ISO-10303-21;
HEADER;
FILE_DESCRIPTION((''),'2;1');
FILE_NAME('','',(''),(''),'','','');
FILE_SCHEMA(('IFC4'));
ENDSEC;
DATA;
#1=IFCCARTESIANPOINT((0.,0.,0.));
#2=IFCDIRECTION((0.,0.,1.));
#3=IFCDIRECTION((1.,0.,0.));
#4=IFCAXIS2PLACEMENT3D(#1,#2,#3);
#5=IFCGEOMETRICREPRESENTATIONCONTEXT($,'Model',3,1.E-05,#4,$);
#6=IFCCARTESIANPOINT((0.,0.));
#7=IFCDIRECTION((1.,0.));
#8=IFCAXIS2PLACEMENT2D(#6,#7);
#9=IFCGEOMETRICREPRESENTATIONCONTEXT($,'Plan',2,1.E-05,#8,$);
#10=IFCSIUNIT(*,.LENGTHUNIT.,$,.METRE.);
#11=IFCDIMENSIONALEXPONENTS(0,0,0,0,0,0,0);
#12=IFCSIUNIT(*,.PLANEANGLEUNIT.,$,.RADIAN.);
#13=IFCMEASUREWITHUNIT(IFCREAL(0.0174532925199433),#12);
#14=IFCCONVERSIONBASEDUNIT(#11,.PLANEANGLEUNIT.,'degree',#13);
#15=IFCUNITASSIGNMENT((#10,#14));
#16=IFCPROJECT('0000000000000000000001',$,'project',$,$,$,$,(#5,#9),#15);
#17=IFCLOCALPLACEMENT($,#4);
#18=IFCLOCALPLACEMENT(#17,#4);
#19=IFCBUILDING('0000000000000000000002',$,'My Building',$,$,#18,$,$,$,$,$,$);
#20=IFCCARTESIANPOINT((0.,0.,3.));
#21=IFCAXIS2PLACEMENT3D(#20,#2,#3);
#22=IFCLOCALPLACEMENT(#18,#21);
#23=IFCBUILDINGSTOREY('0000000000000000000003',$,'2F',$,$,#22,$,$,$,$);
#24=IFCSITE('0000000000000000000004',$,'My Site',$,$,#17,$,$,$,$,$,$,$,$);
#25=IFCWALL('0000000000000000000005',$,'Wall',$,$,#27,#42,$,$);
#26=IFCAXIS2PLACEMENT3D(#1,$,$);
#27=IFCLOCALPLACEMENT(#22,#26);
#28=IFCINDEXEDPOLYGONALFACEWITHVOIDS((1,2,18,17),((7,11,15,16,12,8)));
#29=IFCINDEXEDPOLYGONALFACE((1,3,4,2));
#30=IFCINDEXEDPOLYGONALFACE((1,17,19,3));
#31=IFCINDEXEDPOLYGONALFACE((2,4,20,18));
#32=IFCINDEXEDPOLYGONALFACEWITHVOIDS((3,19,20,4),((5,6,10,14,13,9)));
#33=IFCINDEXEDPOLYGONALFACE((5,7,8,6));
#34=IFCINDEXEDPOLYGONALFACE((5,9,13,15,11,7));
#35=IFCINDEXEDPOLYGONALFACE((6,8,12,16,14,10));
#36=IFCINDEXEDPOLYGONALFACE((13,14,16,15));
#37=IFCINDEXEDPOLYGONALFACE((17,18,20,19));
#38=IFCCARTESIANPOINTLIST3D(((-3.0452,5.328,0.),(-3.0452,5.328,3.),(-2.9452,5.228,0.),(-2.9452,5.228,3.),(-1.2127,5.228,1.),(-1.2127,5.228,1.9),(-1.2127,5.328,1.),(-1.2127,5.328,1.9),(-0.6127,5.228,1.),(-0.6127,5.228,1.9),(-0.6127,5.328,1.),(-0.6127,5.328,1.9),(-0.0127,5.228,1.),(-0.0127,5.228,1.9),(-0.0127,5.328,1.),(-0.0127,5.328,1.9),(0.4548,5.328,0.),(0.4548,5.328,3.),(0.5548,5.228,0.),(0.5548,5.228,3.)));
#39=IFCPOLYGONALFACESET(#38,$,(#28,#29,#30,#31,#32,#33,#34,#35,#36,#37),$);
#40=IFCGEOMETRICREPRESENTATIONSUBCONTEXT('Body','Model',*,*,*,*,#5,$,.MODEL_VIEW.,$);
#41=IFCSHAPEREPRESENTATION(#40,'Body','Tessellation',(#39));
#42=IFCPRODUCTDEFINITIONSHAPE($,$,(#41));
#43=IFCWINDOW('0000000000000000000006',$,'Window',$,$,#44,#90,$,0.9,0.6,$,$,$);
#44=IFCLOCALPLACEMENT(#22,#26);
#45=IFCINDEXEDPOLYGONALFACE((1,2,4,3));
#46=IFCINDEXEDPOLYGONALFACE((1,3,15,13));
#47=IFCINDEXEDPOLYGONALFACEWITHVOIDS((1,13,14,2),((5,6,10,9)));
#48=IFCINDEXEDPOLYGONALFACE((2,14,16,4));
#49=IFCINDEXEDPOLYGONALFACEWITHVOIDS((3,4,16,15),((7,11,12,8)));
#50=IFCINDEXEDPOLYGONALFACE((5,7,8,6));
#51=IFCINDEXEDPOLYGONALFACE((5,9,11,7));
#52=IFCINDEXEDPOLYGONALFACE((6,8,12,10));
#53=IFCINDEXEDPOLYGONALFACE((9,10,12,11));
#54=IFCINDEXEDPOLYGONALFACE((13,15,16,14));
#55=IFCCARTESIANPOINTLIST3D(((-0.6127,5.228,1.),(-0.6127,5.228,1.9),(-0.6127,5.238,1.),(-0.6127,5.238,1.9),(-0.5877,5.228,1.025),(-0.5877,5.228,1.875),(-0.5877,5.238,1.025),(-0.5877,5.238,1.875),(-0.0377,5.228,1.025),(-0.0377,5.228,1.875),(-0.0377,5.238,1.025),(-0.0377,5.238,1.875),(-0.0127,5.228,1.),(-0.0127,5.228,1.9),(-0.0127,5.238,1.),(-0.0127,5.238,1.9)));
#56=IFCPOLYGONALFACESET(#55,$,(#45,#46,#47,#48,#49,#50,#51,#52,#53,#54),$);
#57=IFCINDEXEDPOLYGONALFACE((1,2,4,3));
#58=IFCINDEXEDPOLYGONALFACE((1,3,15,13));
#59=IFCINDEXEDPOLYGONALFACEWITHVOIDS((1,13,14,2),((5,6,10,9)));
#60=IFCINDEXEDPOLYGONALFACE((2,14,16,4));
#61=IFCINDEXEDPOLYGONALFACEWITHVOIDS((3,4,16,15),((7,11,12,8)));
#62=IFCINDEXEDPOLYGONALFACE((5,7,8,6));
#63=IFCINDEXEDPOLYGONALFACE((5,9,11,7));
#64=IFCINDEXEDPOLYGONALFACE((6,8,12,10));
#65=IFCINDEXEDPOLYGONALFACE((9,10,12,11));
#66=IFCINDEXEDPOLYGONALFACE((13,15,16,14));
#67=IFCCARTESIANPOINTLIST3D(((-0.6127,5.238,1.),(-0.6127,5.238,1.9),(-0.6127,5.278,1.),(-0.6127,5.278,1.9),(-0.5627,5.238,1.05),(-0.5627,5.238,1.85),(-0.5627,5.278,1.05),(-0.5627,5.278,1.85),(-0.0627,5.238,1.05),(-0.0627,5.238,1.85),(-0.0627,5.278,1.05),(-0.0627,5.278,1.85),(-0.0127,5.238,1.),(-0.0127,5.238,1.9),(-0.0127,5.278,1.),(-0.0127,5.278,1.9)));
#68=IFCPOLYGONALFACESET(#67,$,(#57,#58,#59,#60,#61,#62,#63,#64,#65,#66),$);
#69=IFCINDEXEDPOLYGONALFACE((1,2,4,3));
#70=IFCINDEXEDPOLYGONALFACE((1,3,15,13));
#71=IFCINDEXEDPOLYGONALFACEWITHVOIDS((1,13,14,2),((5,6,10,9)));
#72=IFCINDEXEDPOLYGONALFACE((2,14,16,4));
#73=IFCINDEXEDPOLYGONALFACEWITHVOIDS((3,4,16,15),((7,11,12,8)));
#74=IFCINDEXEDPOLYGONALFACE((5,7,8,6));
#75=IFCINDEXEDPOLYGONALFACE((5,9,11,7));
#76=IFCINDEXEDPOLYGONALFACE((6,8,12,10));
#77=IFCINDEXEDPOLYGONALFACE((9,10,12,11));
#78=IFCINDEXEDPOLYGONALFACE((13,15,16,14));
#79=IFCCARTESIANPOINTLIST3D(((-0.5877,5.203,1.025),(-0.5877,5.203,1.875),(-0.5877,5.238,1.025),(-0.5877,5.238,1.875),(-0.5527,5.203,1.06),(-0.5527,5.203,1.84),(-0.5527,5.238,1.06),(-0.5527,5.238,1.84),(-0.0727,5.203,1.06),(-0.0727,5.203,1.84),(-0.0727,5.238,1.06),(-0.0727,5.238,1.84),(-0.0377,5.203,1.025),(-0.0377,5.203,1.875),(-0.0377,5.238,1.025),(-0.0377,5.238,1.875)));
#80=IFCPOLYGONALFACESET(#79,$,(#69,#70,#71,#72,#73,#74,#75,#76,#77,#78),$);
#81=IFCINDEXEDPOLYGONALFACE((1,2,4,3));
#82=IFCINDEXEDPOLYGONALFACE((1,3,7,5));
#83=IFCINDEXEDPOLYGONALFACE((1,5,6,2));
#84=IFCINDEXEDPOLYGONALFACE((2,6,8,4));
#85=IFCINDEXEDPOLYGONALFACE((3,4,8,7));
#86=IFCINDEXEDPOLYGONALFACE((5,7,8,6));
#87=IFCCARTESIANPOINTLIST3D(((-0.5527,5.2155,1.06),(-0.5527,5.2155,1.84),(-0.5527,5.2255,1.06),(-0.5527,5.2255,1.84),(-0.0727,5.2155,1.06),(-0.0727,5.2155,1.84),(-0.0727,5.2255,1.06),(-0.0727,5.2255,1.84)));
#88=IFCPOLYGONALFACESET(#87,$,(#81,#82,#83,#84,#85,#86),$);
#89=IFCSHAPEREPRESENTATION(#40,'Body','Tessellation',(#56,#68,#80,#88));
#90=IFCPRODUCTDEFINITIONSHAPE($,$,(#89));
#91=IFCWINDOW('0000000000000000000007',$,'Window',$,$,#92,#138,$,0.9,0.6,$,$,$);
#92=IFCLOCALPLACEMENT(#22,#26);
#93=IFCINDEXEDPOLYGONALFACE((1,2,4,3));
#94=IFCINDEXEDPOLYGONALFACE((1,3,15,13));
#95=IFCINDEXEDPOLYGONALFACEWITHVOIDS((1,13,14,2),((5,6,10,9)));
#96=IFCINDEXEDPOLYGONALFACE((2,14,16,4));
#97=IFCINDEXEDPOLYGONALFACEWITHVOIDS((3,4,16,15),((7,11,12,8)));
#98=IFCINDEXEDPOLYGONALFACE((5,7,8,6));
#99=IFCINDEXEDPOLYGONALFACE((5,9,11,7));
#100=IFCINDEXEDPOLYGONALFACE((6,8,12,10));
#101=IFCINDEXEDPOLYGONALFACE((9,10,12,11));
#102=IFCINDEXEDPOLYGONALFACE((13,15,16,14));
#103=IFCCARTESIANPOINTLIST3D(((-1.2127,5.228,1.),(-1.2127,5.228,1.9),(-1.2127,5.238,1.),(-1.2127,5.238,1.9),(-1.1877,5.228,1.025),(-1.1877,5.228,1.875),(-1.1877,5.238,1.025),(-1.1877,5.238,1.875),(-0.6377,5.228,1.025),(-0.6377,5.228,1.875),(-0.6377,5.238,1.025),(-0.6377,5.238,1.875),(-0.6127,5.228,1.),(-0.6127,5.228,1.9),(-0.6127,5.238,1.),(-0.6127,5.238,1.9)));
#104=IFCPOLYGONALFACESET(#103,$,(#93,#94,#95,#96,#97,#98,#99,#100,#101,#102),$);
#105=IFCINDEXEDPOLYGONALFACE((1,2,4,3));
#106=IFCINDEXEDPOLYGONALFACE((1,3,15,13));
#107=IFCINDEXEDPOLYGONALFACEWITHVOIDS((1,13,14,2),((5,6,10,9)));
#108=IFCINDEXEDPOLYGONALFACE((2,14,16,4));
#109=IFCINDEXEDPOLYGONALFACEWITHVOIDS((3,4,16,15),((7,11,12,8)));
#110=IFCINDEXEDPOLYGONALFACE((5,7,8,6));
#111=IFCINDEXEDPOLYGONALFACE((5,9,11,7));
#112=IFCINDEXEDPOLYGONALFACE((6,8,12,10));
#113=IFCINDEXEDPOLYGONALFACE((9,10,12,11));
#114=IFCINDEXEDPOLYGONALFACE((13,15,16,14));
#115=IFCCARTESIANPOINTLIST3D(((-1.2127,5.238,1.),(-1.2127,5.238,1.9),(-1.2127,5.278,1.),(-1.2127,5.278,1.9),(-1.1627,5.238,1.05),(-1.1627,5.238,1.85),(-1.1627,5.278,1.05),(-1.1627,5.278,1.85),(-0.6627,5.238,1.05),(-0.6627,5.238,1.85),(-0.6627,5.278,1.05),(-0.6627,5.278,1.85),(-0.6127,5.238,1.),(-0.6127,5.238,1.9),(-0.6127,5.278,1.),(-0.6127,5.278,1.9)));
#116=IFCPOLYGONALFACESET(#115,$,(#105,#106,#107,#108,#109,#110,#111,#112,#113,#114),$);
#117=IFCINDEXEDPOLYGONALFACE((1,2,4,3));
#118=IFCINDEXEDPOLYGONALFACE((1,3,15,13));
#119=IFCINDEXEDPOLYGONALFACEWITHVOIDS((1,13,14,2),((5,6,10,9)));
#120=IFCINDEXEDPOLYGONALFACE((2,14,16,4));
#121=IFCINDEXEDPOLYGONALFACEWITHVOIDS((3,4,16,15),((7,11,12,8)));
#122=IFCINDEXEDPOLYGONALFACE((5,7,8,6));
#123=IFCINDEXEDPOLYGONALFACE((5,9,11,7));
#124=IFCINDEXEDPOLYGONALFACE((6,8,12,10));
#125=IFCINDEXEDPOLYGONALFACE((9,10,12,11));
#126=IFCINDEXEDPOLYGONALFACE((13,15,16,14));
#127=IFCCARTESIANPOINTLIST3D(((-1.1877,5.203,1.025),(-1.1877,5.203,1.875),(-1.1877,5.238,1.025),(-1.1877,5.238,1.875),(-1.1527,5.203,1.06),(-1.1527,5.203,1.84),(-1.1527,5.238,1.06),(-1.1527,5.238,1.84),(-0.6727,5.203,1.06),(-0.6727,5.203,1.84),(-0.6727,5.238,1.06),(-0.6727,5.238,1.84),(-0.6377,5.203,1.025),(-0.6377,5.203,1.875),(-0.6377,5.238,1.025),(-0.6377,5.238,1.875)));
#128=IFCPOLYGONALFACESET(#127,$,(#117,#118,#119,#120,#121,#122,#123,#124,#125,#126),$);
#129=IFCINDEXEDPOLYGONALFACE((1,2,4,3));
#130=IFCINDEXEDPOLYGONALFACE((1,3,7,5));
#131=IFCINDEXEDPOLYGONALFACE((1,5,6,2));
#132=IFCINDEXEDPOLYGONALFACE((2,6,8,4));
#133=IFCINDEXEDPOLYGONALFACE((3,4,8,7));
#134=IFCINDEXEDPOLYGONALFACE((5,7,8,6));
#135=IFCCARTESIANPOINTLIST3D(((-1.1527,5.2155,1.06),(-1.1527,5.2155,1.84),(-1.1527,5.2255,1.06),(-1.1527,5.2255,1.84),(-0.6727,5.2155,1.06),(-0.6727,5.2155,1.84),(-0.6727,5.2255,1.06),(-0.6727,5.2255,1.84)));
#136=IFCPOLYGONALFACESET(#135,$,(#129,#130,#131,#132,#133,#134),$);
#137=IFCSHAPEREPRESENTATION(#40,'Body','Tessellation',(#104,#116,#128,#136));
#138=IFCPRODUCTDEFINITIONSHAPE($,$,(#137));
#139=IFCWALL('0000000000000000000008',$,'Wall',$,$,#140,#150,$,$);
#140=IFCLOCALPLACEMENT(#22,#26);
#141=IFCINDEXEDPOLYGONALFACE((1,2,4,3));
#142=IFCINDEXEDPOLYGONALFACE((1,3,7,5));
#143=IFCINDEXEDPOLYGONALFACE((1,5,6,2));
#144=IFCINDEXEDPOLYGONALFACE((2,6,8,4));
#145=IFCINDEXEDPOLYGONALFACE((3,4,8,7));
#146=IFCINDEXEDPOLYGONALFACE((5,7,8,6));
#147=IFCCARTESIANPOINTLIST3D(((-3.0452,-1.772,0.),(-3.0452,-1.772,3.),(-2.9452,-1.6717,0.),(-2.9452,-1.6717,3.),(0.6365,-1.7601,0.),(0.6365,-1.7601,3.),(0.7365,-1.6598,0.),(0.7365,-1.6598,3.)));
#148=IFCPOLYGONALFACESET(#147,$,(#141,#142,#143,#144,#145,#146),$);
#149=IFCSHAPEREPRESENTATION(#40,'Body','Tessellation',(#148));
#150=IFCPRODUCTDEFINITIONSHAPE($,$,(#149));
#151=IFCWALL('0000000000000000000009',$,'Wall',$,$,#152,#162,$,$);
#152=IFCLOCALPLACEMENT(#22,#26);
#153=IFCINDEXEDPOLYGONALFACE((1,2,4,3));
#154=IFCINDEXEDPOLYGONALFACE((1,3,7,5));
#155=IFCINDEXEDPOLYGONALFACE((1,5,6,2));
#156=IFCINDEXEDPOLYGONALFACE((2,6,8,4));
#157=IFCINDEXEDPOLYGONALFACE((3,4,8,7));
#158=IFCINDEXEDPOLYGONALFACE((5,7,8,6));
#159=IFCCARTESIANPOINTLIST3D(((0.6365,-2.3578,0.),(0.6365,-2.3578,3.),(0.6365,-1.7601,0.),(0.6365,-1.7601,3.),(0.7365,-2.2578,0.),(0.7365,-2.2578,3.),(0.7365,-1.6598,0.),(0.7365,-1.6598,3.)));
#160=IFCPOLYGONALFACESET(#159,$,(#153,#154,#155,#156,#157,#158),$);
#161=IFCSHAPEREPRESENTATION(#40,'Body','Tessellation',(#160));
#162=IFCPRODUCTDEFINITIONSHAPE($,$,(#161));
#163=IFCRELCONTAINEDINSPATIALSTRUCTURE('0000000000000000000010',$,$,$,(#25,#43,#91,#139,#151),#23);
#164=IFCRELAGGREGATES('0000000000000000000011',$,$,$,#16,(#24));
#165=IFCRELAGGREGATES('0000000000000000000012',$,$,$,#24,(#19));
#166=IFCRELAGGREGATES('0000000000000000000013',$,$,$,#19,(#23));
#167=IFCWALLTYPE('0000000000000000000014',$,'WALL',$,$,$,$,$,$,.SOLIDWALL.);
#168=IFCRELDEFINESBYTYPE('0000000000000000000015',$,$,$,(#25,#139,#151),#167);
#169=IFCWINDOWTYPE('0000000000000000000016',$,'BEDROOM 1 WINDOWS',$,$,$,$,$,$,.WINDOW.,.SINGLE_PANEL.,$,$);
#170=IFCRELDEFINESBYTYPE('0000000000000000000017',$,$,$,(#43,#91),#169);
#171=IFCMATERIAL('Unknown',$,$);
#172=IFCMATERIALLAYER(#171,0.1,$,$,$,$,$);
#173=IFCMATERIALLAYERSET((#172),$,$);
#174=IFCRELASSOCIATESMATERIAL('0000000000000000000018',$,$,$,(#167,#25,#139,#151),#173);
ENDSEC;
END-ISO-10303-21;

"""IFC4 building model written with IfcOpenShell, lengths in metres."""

from ifc_helpers import new_model, entity, si_unit, converted_unit, frame, origin_with_axes, origin_2d_with_axis, place, context, subcontext, project, spatial, line, indexed_curve, outline, extrude, shape, source, transform, mapped, material, layer, layer_set, layer_usage, type_object, type_shapes, element, fill, save


model = new_model("IFC4")

# Units and contexts
model_context = context("Model", 3, precision=1e-05, world=origin_with_axes())
plan_context = context("Plan", 2, precision=1e-05, world=origin_2d_with_axis())
body_context_1 = subcontext(model_context, "Body", "Model", "MODEL_VIEW")
body_context_2 = subcontext(plan_context, "Body", "Plan", "PLAN_VIEW")
ifc_project = project(units=[si_unit("LENGTHUNIT", "METRE"), converted_unit("PLANEANGLEUNIT", "degree", entity("IfcReal", 0.0174532925199433), si_unit("PLANEANGLEUNIT", "RADIAN"), dimensions=[0, 0, 0, 0, 0, 0, 0])], contexts=[model_context, plan_context])

# Site, building, storey
site_placement = place(None, origin_with_axes())
site = spatial("IfcSite", under=ifc_project, at=site_placement, Name="My Site")
building_placement = place(site_placement, origin_with_axes())
building = spatial("IfcBuilding", under=site, at=building_placement, Name="My Building")
storey_placement = place(building_placement, frame((0.0, 0.0, 3.0), z_axis=(0.0, 0.0, 1.0), x_axis=(1.0, 0.0, 0.0)))
storey = spatial("IfcBuildingStorey", under=building, at=storey_placement, Name="2F")

# Shared definitions
ifc_material = material(Name="Unknown")

# Shared definitions
ifc_layer_1 = layer(ifc_material, 0.1)
ifc_layer_set_1 = layer_set([ifc_layer_1])
wall_type_1 = type_object("IfcWallType", Name="WALL", PredefinedType="SOLIDWALL", material=ifc_layer_set_1)

# Wall, openings, windows
ifc_layer_usage_1 = layer_usage(ifc_layer_set_1, "AXIS2", "POSITIVE", 0.0)
wall_1_placement = place(storey_placement, frame((0.4548, 5.328, 0.0), z_axis=(0.0, 0.0, 1.0), x_axis=(-1.0, 0.0, 0.0)))
wall_1 = element("IfcWall", 1, at=wall_1_placement, inside=storey, type_object=wall_type_1, material=ifc_layer_usage_1, Name="Wall", context=body_context_1, shape_type="SweptSolid", body=[
    extrude(outline(indexed_curve([(0.0, 0.0), (-0.1, 0.1), (3.4, 0.1), (3.5, 0.0)], segments=[line(1, 2, 3, 4, 1)])), origin_with_axes(), (0.0, 0.0, 1.0), 3.0),
])
shared_shape_1 = source(origin_with_axes(), body_context_1, "Body", "SweptSolid", [
    extrude(outline(indexed_curve([(0.0, 0.0), (0.6, 0.0), (0.6, 0.9), (0.0, 0.9)], segments=[line(1, 2, 3, 4, 1)])), frame((0.0, -0.6, 0.0), z_axis=(0.0, -1.0, 0.0), x_axis=(1.0, 0.0, 0.0)), (0.0, 0.0, -1.0), 1.2),
])
opening_1_placement = place(wall_1_placement, frame((0.4674, 0.0, 1.0), z_axis=(0.0, 0.0, 1.0), x_axis=(1.0, 0.0, 0.0)))
opening_1 = element("IfcOpeningElement", 2, at=opening_1_placement, cuts=wall_1, PredefinedType="OPENING", context=body_context_1, shape_type="MappedRepresentation", body=[
    mapped(shared_shape_1, transform((0.0, 0.0, 0.0), x_axis=(1.0, 0.0, 0.0), y_axis=(0.0, 1.0, 0.0), z_axis=(0.0, 0.0, 1.0), scale=1.0)),
])
opening_2_placement = place(wall_1_placement, frame((1.0674, 0.0, 1.0), z_axis=(0.0, 0.0, 1.0), x_axis=(1.0, 0.0, 0.0)))
opening_2 = element("IfcOpeningElement", 3, at=opening_2_placement, cuts=wall_1, PredefinedType="OPENING", context=body_context_1, shape_type="MappedRepresentation", body=[
    mapped(shared_shape_1, transform((0.0, 0.0, 0.0), x_axis=(1.0, 0.0, 0.0), y_axis=(0.0, 1.0, 0.0), z_axis=(0.0, 0.0, 1.0), scale=1.0)),
])
window_type_1 = type_object("IfcWindowType", Name="BEDROOM 1 WINDOWS", PartitioningType="SINGLE_PANEL", PredefinedType="WINDOW")
shared_shape_2 = source(origin_with_axes(), body_context_1, "Body", "SweptSolid", [
    extrude(outline(indexed_curve([(0.0, 0.0), (0.6, 0.0), (0.6, 0.9), (0.0, 0.9)], segments=[line(1, 2, 3, 4, 1)]), holes=[indexed_curve([(0.025, 0.025), (0.575, 0.025), (0.575, 0.875), (0.025, 0.875)], segments=[line(1, 2, 3, 4, 1)])]), frame((0.0, 0.09, 0.0), z_axis=(0.0, -1.0, 0.0), x_axis=(1.0, 0.0, 0.0)), (0.0, 0.0, -1.0), 0.01),
    extrude(outline(indexed_curve([(0.0, 0.0), (0.6, 0.0), (0.6, 0.9), (0.0, 0.9)], segments=[line(1, 2, 3, 4, 1)]), holes=[indexed_curve([(0.05, 0.05), (0.55, 0.05), (0.55, 0.85), (0.05, 0.85)], segments=[line(1, 2, 3, 4, 1)])]), frame((0.0, 0.05, 0.0), z_axis=(0.0, -1.0, 0.0), x_axis=(1.0, 0.0, 0.0)), (0.0, 0.0, -1.0), 0.04),
    extrude(outline(indexed_curve([(0.0, 0.0), (0.55, 0.0), (0.55, 0.85), (0.0, 0.85)], segments=[line(1, 2, 3, 4, 1)]), holes=[indexed_curve([(0.035, 0.035), (0.515, 0.035), (0.515, 0.815), (0.035, 0.815)], segments=[line(1, 2, 3, 4, 1)])]), frame((0.025, 0.09, 0.025), z_axis=(0.0, -1.0, 0.0), x_axis=(1.0, 0.0, 0.0)), (0.0, 0.0, -1.0), 0.035),
    extrude(outline(indexed_curve([(0.035, 0.035), (0.515, 0.035), (0.515, 0.815), (0.035, 0.815)], segments=[line(1, 2, 3, 4, 1)])), frame((0.025, 0.1025, 0.025), z_axis=(0.0, -1.0, 0.0), x_axis=(1.0, 0.0, 0.0)), (0.0, 0.0, -1.0), 0.01),
])
shared_shape_3 = source(origin_with_axes(), body_context_2, "Body", "Curve2D", [
    entity("IfcIndexedPolyCurve", entity("IfcCartesianPointList2D", [[0.05, 0.05], [0.55, 0.05]])),
    entity("IfcIndexedPolyCurve", entity("IfcCartesianPointList2D", [[0.0, 0.1], [0.025, 0.1], [0.025, 0.09], [0.05, 0.09], [0.05, 0.05], [0.0, 0.05]]), [entity("IfcLineIndex", [1, 2, 3, 4, 5, 6, 1])]),
    entity("IfcIndexedPolyCurve", entity("IfcCartesianPointList2D", [[0.6, 0.1], [0.575, 0.1], [0.575, 0.09], [0.55, 0.09], [0.55, 0.05], [0.6, 0.05]]), [entity("IfcLineIndex", [1, 2, 3, 4, 5, 6, 1])]),
    entity("IfcIndexedPolyCurve", entity("IfcCartesianPointList2D", [[0.025, 0.09], [0.06, 0.09], [0.06, 0.125], [0.025, 0.125]]), [entity("IfcLineIndex", [1, 2, 3, 4, 1])]),
    entity("IfcIndexedPolyCurve", entity("IfcCartesianPointList2D", [[0.575, 0.09], [0.54, 0.09], [0.54, 0.125], [0.575, 0.125]]), [entity("IfcLineIndex", [1, 2, 3, 4, 1])]),
    entity("IfcIndexedPolyCurve", entity("IfcCartesianPointList2D", [[0.06, 0.09], [0.54, 0.09]])),
    entity("IfcIndexedPolyCurve", entity("IfcCartesianPointList2D", [[0.06, 0.125], [0.54, 0.125]])),
    entity("IfcIndexedPolyCurve", entity("IfcCartesianPointList2D", [[0.06, 0.1075], [0.54, 0.1075]])),
])
type_shapes(window_type_1, [shared_shape_2, shared_shape_3])
window_1_placement = place(opening_1_placement, origin_with_axes())
window_1 = element("IfcWindow", 4, at=window_1_placement, inside=storey, type_object=window_type_1, Name="Window", OverallHeight=0.9, OverallWidth=0.6, shapes=[
    shape(body_context_1, "Body", "MappedRepresentation", [mapped(shared_shape_2, transform((0.0, 0.0, 0.0), x_axis=(1.0, 0.0, 0.0), y_axis=(0.0, 1.0, 0.0), z_axis=(0.0, 0.0, 1.0), scale=1.0))]),
    shape(body_context_2, "Body", "MappedRepresentation", [mapped(shared_shape_3, transform((0.0, 0.0, 0.0), x_axis=(1.0, 0.0, 0.0), y_axis=(0.0, 1.0, 0.0), z_axis=(0.0, 0.0, 1.0), scale=1.0))]),
])
fill(opening_1, window_1)
window_2_placement = place(opening_2_placement, frame((0.0, 0.0, 0.0), z_axis=(0.0, 0.0, 1.0), x_axis=(1.0, 0.0, 0.0)))
window_2 = element("IfcWindow", 5, at=window_2_placement, inside=storey, type_object=window_type_1, Name="Window", OverallHeight=0.9, OverallWidth=0.6, shapes=[
    shape(body_context_1, "Body", "MappedRepresentation", [mapped(shared_shape_2, transform((0.0, 0.0, 0.0), x_axis=(1.0, 0.0, 0.0), y_axis=(0.0, 1.0, 0.0), z_axis=(0.0, 0.0, 1.0), scale=1.0))]),
    shape(body_context_2, "Body", "MappedRepresentation", [mapped(shared_shape_3, transform((0.0, 0.0, 0.0), x_axis=(1.0, 0.0, 0.0), y_axis=(0.0, 1.0, 0.0), z_axis=(0.0, 0.0, 1.0), scale=1.0))]),
])
fill(opening_2, window_2)

# Walls
ifc_layer_usage_2 = layer_usage(ifc_layer_set_1, "AXIS2", "POSITIVE", 0.0)
wall_2_placement = place(storey_placement, frame((-3.0452, -1.772, 0.0), z_axis=(0.0, 0.0, 1.0), x_axis=(0.999995, 0.00322, 0.0)))
element("IfcWall", 6, at=wall_2_placement, inside=storey, type_object=wall_type_1, material=ifc_layer_usage_2, Name="Wall", context=body_context_1, shape_type="SweptSolid", body=[
    extrude(outline(indexed_curve([(0.0, 0.0), (0.1003, 0.1), (3.782, 0.1), (3.6817, 0.0)], segments=[line(1, 2, 3, 4, 1)])), origin_with_axes(), (0.0, 0.0, 1.0), 3.0),
])
ifc_layer_usage_3 = layer_usage(ifc_layer_set_1, "AXIS2", "POSITIVE", 0.0)
wall_3_placement = place(storey_placement, frame((0.6365, -1.7601, 0.0), z_axis=(0.0, 0.0, 1.0), x_axis=(0.0, -1.0, 0.0)))
element("IfcWall", 7, at=wall_3_placement, inside=storey, type_object=wall_type_1, material=ifc_layer_usage_3, Name="Wall", context=body_context_1, shape_type="SweptSolid", body=[
    extrude(outline(indexed_curve([(0.0, 0.0), (-0.1003, 0.1), (0.4977, 0.1), (0.5977, 0.0)], segments=[line(1, 2, 3, 4, 1)])), origin_with_axes(), (0.0, 0.0, 1.0), 3.0),
])

save(model, "model.ifc")
